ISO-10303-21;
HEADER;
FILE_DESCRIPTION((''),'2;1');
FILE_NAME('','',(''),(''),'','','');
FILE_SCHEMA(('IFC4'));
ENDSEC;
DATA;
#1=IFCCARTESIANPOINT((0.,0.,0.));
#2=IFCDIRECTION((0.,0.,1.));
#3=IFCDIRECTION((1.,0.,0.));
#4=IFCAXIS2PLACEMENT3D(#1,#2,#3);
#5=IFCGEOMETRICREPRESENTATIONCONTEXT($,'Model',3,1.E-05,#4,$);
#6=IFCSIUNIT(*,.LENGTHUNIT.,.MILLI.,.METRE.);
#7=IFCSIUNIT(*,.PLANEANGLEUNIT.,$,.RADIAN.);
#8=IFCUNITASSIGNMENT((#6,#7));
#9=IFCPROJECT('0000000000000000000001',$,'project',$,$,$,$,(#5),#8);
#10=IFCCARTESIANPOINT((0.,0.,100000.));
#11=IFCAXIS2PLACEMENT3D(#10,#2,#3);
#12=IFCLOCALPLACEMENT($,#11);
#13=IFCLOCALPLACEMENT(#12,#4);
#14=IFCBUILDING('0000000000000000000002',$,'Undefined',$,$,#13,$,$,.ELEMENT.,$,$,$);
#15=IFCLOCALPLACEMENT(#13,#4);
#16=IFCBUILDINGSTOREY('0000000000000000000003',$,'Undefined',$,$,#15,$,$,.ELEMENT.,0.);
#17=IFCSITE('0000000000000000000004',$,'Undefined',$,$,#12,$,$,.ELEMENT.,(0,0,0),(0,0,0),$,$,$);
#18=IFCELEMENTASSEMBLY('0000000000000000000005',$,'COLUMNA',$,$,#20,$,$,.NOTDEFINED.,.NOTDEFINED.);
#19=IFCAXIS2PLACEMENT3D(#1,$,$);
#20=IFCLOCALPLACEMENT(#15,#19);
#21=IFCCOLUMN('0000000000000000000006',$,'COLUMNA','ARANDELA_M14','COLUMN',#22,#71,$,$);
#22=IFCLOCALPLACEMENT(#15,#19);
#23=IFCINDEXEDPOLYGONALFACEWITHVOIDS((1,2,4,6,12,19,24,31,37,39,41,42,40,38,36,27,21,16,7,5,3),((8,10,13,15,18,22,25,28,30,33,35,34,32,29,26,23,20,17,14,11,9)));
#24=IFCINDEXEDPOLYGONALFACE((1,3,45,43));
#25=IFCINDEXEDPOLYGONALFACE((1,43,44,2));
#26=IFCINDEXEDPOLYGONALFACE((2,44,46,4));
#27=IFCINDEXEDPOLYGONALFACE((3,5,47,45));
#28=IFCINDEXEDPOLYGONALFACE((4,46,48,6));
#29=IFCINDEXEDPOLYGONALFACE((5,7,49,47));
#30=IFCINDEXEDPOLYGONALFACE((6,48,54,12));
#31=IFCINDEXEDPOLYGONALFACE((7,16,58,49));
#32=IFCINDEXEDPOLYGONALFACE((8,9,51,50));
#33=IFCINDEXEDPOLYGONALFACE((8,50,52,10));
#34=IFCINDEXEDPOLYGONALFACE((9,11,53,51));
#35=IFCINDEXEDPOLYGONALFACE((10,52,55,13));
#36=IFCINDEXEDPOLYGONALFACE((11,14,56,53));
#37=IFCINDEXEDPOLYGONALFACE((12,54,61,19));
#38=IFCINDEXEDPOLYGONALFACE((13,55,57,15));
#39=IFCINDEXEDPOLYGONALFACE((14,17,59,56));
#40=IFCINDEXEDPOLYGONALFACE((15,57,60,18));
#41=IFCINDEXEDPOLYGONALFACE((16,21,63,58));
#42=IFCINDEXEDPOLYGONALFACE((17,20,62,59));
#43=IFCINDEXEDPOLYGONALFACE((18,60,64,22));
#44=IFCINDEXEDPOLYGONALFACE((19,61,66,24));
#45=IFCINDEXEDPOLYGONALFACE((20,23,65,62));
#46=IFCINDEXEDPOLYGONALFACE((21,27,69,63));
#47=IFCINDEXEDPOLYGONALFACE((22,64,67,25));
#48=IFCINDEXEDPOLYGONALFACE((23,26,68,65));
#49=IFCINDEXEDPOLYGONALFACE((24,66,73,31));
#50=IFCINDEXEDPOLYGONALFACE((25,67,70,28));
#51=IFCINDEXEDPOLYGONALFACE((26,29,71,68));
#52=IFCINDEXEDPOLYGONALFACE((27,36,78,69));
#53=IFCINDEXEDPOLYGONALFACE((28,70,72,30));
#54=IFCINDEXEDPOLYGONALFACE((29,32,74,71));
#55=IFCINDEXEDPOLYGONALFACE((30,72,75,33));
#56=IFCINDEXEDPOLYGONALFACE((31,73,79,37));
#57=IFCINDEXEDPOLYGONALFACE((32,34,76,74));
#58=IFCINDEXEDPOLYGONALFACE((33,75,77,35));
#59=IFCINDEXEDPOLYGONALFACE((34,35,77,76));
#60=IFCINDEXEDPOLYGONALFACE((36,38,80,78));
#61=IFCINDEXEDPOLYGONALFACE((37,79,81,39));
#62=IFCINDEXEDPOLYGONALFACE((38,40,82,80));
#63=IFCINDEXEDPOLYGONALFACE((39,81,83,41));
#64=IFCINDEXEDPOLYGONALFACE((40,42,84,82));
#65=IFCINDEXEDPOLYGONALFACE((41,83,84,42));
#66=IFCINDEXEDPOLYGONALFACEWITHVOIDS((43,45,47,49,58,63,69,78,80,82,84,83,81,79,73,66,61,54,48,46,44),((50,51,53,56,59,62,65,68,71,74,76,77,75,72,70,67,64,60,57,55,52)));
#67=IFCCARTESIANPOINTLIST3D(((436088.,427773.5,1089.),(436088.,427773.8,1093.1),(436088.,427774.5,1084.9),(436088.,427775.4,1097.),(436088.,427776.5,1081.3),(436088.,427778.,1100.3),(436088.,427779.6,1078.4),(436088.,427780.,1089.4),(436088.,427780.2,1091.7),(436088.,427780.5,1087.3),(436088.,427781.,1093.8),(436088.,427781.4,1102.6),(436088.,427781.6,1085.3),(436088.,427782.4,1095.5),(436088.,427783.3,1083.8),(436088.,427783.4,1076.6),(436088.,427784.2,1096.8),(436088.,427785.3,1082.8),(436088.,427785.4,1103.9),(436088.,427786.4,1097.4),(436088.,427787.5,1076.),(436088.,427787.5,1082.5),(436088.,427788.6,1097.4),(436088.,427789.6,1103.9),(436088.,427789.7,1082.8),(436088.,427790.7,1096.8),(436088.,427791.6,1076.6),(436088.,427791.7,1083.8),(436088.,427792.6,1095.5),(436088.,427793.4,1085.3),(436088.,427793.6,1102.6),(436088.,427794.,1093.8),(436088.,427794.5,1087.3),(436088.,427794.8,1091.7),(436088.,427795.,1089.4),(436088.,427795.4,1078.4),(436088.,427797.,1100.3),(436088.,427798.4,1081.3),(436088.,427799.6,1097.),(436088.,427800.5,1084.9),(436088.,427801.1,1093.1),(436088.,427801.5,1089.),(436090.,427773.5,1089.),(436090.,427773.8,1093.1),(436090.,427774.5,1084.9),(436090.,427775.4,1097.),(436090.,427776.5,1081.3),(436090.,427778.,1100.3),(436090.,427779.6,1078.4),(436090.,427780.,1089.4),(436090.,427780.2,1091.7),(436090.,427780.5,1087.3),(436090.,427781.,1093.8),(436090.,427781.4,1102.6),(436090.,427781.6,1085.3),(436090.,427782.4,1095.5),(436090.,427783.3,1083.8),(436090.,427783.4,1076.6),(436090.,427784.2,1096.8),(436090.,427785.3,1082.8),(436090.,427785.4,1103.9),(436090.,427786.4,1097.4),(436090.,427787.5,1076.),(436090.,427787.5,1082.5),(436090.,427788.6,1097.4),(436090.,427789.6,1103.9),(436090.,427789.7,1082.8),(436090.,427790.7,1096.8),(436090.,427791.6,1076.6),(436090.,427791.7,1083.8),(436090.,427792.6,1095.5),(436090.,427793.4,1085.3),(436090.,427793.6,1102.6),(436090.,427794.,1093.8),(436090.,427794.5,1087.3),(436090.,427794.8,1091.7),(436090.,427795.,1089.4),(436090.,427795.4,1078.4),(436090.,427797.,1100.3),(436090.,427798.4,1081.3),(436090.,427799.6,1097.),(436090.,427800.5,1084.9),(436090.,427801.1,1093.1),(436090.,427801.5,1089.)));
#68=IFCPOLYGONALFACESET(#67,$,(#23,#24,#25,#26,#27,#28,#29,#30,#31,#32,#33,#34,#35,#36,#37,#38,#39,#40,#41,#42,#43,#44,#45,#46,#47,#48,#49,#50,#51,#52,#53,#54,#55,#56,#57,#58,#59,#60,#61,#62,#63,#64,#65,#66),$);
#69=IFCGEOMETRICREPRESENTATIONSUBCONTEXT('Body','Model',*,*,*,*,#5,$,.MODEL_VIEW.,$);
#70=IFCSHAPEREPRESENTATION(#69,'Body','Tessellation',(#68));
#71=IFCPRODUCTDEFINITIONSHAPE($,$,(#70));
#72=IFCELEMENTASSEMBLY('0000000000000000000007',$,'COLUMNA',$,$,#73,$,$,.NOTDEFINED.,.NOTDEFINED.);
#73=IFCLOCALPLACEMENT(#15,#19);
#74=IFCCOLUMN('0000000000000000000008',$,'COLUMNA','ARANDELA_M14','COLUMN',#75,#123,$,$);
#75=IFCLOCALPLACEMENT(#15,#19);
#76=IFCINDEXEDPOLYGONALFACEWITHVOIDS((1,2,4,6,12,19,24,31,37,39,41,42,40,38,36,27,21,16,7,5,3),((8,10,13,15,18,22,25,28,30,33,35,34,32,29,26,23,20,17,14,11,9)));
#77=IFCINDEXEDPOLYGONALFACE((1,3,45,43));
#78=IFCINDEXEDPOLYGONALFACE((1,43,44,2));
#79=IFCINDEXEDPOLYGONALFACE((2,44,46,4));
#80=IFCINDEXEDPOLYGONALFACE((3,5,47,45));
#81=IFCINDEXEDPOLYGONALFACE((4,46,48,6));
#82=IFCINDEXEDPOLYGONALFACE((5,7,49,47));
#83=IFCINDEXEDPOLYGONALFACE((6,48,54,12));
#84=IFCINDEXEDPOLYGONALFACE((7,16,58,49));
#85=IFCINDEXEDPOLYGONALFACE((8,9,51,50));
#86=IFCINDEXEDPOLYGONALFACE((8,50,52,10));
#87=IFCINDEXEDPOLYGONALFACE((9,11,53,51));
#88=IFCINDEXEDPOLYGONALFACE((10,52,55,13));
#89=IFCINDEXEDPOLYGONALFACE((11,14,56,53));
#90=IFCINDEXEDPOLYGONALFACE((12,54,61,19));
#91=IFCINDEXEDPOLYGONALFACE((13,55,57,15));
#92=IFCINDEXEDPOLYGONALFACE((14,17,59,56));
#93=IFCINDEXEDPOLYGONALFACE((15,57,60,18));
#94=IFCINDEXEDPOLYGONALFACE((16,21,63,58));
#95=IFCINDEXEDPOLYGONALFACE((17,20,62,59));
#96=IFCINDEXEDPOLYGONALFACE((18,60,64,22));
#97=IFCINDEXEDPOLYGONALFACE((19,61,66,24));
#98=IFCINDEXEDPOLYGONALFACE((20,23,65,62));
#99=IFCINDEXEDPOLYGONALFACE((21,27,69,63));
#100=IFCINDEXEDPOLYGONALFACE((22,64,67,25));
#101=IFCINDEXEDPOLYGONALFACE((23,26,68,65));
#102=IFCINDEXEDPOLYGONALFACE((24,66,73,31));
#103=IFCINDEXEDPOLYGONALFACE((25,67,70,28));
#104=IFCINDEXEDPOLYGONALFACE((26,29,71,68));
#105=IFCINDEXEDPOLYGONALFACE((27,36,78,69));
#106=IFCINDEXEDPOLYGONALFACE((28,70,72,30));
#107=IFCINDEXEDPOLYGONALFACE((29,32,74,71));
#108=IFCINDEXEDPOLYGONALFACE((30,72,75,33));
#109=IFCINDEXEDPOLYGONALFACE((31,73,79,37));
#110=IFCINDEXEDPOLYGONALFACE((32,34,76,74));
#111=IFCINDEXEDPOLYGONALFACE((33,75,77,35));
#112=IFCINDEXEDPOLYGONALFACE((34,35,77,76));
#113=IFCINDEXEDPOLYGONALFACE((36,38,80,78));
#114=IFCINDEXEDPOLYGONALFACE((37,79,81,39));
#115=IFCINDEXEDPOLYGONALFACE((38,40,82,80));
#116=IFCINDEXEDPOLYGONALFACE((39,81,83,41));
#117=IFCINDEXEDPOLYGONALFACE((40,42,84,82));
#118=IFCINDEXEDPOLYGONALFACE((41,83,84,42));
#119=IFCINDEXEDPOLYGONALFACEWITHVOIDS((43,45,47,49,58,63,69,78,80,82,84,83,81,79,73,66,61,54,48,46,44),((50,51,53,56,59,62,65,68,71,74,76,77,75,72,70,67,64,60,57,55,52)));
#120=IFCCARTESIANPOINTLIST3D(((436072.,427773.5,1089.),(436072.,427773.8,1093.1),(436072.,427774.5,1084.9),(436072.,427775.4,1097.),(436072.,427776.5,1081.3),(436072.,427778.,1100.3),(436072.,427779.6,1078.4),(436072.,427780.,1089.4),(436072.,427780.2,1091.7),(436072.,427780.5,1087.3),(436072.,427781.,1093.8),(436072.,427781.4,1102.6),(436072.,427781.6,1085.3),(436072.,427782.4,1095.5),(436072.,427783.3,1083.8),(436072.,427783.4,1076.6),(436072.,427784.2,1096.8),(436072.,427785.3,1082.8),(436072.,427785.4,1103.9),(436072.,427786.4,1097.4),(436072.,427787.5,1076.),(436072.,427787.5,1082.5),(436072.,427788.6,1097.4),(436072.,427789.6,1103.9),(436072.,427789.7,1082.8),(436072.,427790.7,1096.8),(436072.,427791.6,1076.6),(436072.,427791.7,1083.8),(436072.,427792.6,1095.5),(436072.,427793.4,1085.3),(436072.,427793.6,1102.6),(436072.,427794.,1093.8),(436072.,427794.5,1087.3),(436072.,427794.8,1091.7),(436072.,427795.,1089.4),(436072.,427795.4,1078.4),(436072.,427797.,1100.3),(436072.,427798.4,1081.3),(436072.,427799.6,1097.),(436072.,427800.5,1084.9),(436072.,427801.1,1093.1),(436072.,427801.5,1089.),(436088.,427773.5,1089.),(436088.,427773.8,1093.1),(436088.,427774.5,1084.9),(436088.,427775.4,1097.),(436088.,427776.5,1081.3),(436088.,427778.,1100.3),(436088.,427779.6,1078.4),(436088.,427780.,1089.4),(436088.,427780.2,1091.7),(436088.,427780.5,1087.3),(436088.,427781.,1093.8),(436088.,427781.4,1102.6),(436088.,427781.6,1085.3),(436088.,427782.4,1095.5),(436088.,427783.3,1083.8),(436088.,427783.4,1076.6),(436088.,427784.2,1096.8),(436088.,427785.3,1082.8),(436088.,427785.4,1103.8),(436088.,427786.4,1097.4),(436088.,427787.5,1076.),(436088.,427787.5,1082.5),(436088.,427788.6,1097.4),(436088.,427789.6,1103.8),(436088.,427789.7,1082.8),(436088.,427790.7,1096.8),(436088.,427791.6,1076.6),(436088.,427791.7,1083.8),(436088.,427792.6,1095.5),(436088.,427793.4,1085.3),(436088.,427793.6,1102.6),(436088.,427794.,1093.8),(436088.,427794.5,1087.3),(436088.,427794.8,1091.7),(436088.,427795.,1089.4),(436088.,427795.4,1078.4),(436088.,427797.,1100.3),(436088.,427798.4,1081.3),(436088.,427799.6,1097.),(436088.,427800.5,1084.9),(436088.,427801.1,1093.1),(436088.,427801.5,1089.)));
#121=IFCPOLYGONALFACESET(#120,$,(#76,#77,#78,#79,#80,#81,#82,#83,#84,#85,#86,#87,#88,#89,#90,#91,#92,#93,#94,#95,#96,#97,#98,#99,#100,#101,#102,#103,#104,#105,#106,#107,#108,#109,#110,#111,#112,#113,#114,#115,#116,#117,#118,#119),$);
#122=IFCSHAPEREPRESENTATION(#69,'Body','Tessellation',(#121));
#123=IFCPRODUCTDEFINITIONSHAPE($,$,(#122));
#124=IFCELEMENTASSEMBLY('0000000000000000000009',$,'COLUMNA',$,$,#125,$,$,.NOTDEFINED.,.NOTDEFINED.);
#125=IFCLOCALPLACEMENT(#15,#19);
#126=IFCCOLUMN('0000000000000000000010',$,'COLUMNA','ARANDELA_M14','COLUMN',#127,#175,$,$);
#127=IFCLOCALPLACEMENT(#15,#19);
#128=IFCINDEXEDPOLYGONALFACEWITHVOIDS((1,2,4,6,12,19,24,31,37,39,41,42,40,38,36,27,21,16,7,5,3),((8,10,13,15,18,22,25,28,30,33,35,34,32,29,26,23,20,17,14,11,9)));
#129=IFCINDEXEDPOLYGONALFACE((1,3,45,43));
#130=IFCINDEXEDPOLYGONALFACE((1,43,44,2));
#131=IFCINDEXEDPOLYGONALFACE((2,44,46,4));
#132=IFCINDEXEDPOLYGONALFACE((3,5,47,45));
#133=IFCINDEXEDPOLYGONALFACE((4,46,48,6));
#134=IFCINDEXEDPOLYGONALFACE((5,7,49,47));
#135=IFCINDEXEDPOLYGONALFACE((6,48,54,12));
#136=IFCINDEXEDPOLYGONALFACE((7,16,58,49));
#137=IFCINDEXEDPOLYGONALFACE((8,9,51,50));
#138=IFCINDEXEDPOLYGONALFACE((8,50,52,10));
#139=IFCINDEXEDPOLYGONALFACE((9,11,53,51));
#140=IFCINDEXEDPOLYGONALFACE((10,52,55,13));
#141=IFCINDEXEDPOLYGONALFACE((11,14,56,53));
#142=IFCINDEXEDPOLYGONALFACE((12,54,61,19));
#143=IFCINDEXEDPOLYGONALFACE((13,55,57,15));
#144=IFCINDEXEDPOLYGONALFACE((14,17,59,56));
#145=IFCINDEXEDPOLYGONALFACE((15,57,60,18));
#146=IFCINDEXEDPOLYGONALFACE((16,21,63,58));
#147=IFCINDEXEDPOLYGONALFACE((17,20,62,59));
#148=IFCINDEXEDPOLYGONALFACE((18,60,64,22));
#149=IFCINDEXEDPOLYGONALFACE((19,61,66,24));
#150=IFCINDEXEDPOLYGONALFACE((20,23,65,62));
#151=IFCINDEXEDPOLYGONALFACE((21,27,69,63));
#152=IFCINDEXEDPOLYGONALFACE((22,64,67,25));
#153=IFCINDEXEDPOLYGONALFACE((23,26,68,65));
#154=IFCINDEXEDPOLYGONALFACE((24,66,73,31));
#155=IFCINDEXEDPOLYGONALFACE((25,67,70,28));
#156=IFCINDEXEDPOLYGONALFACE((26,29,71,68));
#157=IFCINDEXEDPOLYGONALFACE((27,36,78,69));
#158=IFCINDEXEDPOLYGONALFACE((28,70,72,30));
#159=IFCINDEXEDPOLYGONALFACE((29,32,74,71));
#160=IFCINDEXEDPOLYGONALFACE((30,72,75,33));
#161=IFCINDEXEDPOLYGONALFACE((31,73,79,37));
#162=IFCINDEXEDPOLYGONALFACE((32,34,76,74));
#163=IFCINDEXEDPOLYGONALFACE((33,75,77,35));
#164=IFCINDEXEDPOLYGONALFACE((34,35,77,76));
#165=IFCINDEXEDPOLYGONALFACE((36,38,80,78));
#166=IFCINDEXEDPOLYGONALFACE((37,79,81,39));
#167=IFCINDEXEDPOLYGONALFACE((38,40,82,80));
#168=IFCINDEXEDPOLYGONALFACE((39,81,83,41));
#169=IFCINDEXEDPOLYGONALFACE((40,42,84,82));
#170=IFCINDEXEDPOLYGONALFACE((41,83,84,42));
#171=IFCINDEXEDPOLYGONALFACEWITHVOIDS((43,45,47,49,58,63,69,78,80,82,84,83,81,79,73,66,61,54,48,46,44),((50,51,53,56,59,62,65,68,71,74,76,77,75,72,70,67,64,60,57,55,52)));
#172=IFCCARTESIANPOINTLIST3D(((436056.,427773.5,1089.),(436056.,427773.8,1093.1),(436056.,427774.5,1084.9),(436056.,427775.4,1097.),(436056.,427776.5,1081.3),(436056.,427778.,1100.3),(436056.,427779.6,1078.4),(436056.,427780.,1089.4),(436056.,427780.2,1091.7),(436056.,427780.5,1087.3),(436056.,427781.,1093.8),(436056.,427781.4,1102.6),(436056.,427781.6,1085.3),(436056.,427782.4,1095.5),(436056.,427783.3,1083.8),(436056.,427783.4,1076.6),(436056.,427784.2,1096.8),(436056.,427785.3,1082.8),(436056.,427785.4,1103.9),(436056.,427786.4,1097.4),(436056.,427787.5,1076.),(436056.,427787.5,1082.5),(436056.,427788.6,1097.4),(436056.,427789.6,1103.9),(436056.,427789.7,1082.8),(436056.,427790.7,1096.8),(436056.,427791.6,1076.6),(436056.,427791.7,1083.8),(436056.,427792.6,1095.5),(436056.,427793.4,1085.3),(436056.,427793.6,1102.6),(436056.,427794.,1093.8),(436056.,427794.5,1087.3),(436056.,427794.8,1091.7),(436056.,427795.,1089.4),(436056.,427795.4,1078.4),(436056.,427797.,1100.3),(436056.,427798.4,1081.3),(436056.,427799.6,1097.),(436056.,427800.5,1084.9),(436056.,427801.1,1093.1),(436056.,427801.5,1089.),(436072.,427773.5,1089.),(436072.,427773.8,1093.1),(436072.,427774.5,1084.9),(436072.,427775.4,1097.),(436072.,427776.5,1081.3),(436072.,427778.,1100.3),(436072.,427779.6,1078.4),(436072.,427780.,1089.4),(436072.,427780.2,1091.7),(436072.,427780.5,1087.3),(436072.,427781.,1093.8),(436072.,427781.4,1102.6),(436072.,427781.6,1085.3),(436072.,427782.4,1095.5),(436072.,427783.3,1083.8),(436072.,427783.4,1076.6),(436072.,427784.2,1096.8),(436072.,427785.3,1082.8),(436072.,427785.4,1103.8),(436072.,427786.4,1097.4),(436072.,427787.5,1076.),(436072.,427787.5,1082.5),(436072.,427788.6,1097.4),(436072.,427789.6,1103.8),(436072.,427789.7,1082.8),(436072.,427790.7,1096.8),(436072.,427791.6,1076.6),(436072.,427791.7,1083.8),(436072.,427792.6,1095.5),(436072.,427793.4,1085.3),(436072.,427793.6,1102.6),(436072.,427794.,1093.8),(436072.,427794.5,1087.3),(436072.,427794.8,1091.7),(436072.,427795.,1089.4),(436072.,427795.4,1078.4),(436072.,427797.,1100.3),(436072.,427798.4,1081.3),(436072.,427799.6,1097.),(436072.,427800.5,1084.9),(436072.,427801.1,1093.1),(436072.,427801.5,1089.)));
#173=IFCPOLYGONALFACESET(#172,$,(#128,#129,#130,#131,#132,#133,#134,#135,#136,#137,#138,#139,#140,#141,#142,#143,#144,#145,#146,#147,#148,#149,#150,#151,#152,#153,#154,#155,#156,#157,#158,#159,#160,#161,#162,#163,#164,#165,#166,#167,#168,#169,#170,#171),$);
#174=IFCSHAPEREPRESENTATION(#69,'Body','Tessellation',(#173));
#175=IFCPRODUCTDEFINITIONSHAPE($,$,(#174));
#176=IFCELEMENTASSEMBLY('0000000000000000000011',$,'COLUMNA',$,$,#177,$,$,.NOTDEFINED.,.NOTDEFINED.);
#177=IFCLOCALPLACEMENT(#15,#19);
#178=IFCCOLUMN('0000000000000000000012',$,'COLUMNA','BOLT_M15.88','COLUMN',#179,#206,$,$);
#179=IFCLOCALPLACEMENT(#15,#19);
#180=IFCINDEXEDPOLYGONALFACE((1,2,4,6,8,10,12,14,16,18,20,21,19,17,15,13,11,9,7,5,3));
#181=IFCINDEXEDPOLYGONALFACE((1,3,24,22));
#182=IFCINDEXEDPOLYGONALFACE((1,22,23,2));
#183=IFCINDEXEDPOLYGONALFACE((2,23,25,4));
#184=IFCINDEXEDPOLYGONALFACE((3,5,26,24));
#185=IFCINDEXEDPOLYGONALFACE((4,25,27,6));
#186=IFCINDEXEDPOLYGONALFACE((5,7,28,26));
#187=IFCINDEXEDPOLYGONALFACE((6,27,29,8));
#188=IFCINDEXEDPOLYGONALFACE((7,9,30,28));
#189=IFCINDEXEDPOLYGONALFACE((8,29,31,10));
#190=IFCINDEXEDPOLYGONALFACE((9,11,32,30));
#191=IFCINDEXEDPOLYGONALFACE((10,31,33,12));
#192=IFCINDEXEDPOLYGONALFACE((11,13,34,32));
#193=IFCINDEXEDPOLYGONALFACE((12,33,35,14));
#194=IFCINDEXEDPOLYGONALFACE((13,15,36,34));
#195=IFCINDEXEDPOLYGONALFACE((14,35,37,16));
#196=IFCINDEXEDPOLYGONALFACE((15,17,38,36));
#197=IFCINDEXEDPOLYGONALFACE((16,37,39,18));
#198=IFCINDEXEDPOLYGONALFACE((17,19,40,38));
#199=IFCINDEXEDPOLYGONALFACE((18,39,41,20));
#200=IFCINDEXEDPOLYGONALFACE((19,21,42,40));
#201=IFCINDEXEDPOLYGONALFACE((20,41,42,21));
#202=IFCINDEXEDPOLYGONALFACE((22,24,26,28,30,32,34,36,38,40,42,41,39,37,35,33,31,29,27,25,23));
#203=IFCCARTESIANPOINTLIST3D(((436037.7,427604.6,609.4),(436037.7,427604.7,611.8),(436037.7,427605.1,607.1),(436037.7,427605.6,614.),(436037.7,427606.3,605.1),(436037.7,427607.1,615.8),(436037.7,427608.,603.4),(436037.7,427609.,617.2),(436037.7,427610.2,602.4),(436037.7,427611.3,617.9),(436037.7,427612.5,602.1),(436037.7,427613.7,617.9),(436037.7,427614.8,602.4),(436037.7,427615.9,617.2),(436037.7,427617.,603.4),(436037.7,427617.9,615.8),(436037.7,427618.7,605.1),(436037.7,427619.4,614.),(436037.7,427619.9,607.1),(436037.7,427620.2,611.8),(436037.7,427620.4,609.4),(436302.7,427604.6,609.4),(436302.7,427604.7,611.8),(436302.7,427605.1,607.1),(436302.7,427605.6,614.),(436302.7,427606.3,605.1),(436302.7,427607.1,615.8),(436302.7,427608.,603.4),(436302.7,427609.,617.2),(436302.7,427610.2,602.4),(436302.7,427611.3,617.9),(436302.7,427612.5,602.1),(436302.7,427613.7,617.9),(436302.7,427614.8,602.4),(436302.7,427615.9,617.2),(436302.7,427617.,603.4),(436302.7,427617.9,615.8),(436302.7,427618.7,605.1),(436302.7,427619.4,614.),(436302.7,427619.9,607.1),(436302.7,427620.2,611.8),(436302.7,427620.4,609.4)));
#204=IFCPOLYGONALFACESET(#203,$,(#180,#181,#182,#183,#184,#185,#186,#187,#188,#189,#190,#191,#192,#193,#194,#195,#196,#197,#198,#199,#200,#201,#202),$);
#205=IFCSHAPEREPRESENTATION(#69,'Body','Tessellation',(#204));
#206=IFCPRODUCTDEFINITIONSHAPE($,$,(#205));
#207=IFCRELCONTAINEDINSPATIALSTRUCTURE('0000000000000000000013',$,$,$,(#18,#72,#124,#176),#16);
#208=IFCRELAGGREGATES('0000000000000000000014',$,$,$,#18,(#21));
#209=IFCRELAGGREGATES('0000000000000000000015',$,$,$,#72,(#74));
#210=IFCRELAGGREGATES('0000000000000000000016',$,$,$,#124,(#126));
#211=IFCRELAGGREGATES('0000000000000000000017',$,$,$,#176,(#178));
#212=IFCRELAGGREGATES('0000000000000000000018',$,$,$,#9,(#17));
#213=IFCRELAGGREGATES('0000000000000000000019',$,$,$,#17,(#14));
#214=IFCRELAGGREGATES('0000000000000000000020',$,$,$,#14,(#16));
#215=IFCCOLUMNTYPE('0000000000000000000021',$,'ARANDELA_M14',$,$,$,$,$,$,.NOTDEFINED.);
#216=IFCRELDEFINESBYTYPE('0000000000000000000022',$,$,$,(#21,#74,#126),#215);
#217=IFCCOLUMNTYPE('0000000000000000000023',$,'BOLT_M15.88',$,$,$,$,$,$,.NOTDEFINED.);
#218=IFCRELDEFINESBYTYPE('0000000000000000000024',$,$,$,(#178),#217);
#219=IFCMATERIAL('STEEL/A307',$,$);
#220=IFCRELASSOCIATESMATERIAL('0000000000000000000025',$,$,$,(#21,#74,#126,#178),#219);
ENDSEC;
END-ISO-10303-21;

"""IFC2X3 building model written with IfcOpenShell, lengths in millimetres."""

from ifc_helpers import new_model, si_unit, frame, origin_with_axes, origin_2d_with_axis, place, context, subcontext, project, spatial, circle, hollow_circle, extrude, material, type_object, element, aggregate, save


model = new_model("IFC2X3")

# Units and contexts
model_context = context("Model", 3, precision=1e-05, world=origin_with_axes())
body_context = subcontext(model_context, "Body", "Model", "MODEL_VIEW")
ifc_project = project(units=[si_unit("LENGTHUNIT", "METRE", prefix="MILLI"), si_unit("PLANEANGLEUNIT", "RADIAN")], contexts=[model_context])

# Site, building, storey
site_placement = place(None, frame((0.0, 0.0, 100000.0), z_axis=(0.0, 0.0, 1.0), x_axis=(1.0, 0.0, 0.0)))
site = spatial("IfcSite", under=ifc_project, at=site_placement, Name="Undefined", CompositionType="ELEMENT", RefLatitude=(0, 0, 0), RefLongitude=(0, 0, 0))
building_placement = place(site_placement, origin_with_axes())
building = spatial("IfcBuilding", under=site, at=building_placement, Name="Undefined", CompositionType="ELEMENT")
storey_placement = place(building_placement, origin_with_axes())
storey = spatial("IfcBuildingStorey", under=building, at=storey_placement, Name="Undefined", CompositionType="ELEMENT", Elevation=0.0)

# Element assemblies, columns
ifc_material_1 = material(Name="STEEL/A307")
column_type_1 = type_object("IfcColumnType", Name="ARANDELA_M14", PredefinedType="NOTDEFINED")
assembly_1_placement = place(storey_placement, origin_with_axes())
assembly_1 = element("IfcElementAssembly", 1, at=assembly_1_placement, inside=storey, Name="COLUMNA", AssemblyPlace="NOTDEFINED", PredefinedType="NOTDEFINED")
column_1_placement = place(assembly_1_placement, frame((436090.0, 427787.5, 1090.0), z_axis=(-1.0, 0.0, 0.000285), x_axis=(0.0, 1.0, 0.0)))
column_1 = element("IfcColumn", 2, at=column_1_placement, type_object=column_type_1, material=ifc_material_1, Name="COLUMNA", Description="ARANDELA_M14", ObjectType="COLUMN", context=body_context, shape_type="SweptSolid", body=[
    extrude(hollow_circle(Radius=14.0, WallThickness=6.5, at=origin_2d_with_axis()), frame((0.0, 0.0, 2.0), z_axis=(0.0, 0.0, -1.0), x_axis=(0.0, 1.0, 0.0)), (0.0, 0.0, 1.0), 2.0),
])
aggregate(assembly_1, [column_1])
assembly_2_placement = place(storey_placement, origin_with_axes())
assembly_2 = element("IfcElementAssembly", 3, at=assembly_2_placement, inside=storey, Name="COLUMNA", AssemblyPlace="NOTDEFINED", PredefinedType="NOTDEFINED")
column_2_placement = place(assembly_2_placement, frame((436088.0, 427787.5, 1090.0), z_axis=(-1.0, 0.0, 0.000285), x_axis=(0.0, 1.0, 0.0)))
column_2 = element("IfcColumn", 4, at=column_2_placement, type_object=column_type_1, material=ifc_material_1, Name="COLUMNA", Description="ARANDELA_M14", ObjectType="COLUMN", context=body_context, shape_type="SweptSolid", body=[
    extrude(hollow_circle(Radius=14.0, WallThickness=6.5, at=origin_2d_with_axis()), frame((0.0, 0.0, 16.0), z_axis=(0.0, 0.0, -1.0), x_axis=(0.0, 1.0, 0.0)), (0.0, 0.0, 1.0), 16.0),
])
aggregate(assembly_2, [column_2])
assembly_3_placement = place(storey_placement, origin_with_axes())
assembly_3 = element("IfcElementAssembly", 5, at=assembly_3_placement, inside=storey, Name="COLUMNA", AssemblyPlace="NOTDEFINED", PredefinedType="NOTDEFINED")
column_3_placement = place(assembly_3_placement, frame((436072.0, 427787.5, 1090.0), z_axis=(-1.0, 0.0, 0.000285), x_axis=(0.0, 1.0, 0.0)))
column_3 = element("IfcColumn", 6, at=column_3_placement, type_object=column_type_1, material=ifc_material_1, Name="COLUMNA", Description="ARANDELA_M14", ObjectType="COLUMN", context=body_context, shape_type="SweptSolid", body=[
    extrude(hollow_circle(Radius=14.0, WallThickness=6.5, at=origin_2d_with_axis()), frame((0.0, 0.0, 16.0), z_axis=(0.0, 0.0, -1.0), x_axis=(0.0, 1.0, 0.0)), (0.0, 0.0, 1.0), 16.0),
])
aggregate(assembly_3, [column_3])
assembly_4_placement = place(storey_placement, origin_with_axes())
assembly_4 = element("IfcElementAssembly", 7, at=assembly_4_placement, inside=storey, Name="COLUMNA", AssemblyPlace="NOTDEFINED", PredefinedType="NOTDEFINED")
column_type_2 = type_object("IfcColumnType", Name="BOLT_M15.88", PredefinedType="NOTDEFINED")
column_4_placement = place(assembly_4_placement, frame((436302.7, 427612.5, 610.0), z_axis=(-1.0, 0.0, -0.000003), x_axis=(0.0, 1.0, 0.0)))
column_4 = element("IfcColumn", 8, at=column_4_placement, type_object=column_type_2, material=ifc_material_1, Name="COLUMNA", Description="BOLT_M15.88", ObjectType="COLUMN", context=body_context, shape_type="SweptSolid", body=[
    extrude(circle(Radius=7.9, at=origin_2d_with_axis()), frame((0.0, 0.0, 265.0), z_axis=(0.0, 0.0, -1.0), x_axis=(0.0, 1.0, 0.0)), (0.0, 0.0, 1.0), 265.0),
])
aggregate(assembly_4, [column_4])

save(model, "model.ifc")
